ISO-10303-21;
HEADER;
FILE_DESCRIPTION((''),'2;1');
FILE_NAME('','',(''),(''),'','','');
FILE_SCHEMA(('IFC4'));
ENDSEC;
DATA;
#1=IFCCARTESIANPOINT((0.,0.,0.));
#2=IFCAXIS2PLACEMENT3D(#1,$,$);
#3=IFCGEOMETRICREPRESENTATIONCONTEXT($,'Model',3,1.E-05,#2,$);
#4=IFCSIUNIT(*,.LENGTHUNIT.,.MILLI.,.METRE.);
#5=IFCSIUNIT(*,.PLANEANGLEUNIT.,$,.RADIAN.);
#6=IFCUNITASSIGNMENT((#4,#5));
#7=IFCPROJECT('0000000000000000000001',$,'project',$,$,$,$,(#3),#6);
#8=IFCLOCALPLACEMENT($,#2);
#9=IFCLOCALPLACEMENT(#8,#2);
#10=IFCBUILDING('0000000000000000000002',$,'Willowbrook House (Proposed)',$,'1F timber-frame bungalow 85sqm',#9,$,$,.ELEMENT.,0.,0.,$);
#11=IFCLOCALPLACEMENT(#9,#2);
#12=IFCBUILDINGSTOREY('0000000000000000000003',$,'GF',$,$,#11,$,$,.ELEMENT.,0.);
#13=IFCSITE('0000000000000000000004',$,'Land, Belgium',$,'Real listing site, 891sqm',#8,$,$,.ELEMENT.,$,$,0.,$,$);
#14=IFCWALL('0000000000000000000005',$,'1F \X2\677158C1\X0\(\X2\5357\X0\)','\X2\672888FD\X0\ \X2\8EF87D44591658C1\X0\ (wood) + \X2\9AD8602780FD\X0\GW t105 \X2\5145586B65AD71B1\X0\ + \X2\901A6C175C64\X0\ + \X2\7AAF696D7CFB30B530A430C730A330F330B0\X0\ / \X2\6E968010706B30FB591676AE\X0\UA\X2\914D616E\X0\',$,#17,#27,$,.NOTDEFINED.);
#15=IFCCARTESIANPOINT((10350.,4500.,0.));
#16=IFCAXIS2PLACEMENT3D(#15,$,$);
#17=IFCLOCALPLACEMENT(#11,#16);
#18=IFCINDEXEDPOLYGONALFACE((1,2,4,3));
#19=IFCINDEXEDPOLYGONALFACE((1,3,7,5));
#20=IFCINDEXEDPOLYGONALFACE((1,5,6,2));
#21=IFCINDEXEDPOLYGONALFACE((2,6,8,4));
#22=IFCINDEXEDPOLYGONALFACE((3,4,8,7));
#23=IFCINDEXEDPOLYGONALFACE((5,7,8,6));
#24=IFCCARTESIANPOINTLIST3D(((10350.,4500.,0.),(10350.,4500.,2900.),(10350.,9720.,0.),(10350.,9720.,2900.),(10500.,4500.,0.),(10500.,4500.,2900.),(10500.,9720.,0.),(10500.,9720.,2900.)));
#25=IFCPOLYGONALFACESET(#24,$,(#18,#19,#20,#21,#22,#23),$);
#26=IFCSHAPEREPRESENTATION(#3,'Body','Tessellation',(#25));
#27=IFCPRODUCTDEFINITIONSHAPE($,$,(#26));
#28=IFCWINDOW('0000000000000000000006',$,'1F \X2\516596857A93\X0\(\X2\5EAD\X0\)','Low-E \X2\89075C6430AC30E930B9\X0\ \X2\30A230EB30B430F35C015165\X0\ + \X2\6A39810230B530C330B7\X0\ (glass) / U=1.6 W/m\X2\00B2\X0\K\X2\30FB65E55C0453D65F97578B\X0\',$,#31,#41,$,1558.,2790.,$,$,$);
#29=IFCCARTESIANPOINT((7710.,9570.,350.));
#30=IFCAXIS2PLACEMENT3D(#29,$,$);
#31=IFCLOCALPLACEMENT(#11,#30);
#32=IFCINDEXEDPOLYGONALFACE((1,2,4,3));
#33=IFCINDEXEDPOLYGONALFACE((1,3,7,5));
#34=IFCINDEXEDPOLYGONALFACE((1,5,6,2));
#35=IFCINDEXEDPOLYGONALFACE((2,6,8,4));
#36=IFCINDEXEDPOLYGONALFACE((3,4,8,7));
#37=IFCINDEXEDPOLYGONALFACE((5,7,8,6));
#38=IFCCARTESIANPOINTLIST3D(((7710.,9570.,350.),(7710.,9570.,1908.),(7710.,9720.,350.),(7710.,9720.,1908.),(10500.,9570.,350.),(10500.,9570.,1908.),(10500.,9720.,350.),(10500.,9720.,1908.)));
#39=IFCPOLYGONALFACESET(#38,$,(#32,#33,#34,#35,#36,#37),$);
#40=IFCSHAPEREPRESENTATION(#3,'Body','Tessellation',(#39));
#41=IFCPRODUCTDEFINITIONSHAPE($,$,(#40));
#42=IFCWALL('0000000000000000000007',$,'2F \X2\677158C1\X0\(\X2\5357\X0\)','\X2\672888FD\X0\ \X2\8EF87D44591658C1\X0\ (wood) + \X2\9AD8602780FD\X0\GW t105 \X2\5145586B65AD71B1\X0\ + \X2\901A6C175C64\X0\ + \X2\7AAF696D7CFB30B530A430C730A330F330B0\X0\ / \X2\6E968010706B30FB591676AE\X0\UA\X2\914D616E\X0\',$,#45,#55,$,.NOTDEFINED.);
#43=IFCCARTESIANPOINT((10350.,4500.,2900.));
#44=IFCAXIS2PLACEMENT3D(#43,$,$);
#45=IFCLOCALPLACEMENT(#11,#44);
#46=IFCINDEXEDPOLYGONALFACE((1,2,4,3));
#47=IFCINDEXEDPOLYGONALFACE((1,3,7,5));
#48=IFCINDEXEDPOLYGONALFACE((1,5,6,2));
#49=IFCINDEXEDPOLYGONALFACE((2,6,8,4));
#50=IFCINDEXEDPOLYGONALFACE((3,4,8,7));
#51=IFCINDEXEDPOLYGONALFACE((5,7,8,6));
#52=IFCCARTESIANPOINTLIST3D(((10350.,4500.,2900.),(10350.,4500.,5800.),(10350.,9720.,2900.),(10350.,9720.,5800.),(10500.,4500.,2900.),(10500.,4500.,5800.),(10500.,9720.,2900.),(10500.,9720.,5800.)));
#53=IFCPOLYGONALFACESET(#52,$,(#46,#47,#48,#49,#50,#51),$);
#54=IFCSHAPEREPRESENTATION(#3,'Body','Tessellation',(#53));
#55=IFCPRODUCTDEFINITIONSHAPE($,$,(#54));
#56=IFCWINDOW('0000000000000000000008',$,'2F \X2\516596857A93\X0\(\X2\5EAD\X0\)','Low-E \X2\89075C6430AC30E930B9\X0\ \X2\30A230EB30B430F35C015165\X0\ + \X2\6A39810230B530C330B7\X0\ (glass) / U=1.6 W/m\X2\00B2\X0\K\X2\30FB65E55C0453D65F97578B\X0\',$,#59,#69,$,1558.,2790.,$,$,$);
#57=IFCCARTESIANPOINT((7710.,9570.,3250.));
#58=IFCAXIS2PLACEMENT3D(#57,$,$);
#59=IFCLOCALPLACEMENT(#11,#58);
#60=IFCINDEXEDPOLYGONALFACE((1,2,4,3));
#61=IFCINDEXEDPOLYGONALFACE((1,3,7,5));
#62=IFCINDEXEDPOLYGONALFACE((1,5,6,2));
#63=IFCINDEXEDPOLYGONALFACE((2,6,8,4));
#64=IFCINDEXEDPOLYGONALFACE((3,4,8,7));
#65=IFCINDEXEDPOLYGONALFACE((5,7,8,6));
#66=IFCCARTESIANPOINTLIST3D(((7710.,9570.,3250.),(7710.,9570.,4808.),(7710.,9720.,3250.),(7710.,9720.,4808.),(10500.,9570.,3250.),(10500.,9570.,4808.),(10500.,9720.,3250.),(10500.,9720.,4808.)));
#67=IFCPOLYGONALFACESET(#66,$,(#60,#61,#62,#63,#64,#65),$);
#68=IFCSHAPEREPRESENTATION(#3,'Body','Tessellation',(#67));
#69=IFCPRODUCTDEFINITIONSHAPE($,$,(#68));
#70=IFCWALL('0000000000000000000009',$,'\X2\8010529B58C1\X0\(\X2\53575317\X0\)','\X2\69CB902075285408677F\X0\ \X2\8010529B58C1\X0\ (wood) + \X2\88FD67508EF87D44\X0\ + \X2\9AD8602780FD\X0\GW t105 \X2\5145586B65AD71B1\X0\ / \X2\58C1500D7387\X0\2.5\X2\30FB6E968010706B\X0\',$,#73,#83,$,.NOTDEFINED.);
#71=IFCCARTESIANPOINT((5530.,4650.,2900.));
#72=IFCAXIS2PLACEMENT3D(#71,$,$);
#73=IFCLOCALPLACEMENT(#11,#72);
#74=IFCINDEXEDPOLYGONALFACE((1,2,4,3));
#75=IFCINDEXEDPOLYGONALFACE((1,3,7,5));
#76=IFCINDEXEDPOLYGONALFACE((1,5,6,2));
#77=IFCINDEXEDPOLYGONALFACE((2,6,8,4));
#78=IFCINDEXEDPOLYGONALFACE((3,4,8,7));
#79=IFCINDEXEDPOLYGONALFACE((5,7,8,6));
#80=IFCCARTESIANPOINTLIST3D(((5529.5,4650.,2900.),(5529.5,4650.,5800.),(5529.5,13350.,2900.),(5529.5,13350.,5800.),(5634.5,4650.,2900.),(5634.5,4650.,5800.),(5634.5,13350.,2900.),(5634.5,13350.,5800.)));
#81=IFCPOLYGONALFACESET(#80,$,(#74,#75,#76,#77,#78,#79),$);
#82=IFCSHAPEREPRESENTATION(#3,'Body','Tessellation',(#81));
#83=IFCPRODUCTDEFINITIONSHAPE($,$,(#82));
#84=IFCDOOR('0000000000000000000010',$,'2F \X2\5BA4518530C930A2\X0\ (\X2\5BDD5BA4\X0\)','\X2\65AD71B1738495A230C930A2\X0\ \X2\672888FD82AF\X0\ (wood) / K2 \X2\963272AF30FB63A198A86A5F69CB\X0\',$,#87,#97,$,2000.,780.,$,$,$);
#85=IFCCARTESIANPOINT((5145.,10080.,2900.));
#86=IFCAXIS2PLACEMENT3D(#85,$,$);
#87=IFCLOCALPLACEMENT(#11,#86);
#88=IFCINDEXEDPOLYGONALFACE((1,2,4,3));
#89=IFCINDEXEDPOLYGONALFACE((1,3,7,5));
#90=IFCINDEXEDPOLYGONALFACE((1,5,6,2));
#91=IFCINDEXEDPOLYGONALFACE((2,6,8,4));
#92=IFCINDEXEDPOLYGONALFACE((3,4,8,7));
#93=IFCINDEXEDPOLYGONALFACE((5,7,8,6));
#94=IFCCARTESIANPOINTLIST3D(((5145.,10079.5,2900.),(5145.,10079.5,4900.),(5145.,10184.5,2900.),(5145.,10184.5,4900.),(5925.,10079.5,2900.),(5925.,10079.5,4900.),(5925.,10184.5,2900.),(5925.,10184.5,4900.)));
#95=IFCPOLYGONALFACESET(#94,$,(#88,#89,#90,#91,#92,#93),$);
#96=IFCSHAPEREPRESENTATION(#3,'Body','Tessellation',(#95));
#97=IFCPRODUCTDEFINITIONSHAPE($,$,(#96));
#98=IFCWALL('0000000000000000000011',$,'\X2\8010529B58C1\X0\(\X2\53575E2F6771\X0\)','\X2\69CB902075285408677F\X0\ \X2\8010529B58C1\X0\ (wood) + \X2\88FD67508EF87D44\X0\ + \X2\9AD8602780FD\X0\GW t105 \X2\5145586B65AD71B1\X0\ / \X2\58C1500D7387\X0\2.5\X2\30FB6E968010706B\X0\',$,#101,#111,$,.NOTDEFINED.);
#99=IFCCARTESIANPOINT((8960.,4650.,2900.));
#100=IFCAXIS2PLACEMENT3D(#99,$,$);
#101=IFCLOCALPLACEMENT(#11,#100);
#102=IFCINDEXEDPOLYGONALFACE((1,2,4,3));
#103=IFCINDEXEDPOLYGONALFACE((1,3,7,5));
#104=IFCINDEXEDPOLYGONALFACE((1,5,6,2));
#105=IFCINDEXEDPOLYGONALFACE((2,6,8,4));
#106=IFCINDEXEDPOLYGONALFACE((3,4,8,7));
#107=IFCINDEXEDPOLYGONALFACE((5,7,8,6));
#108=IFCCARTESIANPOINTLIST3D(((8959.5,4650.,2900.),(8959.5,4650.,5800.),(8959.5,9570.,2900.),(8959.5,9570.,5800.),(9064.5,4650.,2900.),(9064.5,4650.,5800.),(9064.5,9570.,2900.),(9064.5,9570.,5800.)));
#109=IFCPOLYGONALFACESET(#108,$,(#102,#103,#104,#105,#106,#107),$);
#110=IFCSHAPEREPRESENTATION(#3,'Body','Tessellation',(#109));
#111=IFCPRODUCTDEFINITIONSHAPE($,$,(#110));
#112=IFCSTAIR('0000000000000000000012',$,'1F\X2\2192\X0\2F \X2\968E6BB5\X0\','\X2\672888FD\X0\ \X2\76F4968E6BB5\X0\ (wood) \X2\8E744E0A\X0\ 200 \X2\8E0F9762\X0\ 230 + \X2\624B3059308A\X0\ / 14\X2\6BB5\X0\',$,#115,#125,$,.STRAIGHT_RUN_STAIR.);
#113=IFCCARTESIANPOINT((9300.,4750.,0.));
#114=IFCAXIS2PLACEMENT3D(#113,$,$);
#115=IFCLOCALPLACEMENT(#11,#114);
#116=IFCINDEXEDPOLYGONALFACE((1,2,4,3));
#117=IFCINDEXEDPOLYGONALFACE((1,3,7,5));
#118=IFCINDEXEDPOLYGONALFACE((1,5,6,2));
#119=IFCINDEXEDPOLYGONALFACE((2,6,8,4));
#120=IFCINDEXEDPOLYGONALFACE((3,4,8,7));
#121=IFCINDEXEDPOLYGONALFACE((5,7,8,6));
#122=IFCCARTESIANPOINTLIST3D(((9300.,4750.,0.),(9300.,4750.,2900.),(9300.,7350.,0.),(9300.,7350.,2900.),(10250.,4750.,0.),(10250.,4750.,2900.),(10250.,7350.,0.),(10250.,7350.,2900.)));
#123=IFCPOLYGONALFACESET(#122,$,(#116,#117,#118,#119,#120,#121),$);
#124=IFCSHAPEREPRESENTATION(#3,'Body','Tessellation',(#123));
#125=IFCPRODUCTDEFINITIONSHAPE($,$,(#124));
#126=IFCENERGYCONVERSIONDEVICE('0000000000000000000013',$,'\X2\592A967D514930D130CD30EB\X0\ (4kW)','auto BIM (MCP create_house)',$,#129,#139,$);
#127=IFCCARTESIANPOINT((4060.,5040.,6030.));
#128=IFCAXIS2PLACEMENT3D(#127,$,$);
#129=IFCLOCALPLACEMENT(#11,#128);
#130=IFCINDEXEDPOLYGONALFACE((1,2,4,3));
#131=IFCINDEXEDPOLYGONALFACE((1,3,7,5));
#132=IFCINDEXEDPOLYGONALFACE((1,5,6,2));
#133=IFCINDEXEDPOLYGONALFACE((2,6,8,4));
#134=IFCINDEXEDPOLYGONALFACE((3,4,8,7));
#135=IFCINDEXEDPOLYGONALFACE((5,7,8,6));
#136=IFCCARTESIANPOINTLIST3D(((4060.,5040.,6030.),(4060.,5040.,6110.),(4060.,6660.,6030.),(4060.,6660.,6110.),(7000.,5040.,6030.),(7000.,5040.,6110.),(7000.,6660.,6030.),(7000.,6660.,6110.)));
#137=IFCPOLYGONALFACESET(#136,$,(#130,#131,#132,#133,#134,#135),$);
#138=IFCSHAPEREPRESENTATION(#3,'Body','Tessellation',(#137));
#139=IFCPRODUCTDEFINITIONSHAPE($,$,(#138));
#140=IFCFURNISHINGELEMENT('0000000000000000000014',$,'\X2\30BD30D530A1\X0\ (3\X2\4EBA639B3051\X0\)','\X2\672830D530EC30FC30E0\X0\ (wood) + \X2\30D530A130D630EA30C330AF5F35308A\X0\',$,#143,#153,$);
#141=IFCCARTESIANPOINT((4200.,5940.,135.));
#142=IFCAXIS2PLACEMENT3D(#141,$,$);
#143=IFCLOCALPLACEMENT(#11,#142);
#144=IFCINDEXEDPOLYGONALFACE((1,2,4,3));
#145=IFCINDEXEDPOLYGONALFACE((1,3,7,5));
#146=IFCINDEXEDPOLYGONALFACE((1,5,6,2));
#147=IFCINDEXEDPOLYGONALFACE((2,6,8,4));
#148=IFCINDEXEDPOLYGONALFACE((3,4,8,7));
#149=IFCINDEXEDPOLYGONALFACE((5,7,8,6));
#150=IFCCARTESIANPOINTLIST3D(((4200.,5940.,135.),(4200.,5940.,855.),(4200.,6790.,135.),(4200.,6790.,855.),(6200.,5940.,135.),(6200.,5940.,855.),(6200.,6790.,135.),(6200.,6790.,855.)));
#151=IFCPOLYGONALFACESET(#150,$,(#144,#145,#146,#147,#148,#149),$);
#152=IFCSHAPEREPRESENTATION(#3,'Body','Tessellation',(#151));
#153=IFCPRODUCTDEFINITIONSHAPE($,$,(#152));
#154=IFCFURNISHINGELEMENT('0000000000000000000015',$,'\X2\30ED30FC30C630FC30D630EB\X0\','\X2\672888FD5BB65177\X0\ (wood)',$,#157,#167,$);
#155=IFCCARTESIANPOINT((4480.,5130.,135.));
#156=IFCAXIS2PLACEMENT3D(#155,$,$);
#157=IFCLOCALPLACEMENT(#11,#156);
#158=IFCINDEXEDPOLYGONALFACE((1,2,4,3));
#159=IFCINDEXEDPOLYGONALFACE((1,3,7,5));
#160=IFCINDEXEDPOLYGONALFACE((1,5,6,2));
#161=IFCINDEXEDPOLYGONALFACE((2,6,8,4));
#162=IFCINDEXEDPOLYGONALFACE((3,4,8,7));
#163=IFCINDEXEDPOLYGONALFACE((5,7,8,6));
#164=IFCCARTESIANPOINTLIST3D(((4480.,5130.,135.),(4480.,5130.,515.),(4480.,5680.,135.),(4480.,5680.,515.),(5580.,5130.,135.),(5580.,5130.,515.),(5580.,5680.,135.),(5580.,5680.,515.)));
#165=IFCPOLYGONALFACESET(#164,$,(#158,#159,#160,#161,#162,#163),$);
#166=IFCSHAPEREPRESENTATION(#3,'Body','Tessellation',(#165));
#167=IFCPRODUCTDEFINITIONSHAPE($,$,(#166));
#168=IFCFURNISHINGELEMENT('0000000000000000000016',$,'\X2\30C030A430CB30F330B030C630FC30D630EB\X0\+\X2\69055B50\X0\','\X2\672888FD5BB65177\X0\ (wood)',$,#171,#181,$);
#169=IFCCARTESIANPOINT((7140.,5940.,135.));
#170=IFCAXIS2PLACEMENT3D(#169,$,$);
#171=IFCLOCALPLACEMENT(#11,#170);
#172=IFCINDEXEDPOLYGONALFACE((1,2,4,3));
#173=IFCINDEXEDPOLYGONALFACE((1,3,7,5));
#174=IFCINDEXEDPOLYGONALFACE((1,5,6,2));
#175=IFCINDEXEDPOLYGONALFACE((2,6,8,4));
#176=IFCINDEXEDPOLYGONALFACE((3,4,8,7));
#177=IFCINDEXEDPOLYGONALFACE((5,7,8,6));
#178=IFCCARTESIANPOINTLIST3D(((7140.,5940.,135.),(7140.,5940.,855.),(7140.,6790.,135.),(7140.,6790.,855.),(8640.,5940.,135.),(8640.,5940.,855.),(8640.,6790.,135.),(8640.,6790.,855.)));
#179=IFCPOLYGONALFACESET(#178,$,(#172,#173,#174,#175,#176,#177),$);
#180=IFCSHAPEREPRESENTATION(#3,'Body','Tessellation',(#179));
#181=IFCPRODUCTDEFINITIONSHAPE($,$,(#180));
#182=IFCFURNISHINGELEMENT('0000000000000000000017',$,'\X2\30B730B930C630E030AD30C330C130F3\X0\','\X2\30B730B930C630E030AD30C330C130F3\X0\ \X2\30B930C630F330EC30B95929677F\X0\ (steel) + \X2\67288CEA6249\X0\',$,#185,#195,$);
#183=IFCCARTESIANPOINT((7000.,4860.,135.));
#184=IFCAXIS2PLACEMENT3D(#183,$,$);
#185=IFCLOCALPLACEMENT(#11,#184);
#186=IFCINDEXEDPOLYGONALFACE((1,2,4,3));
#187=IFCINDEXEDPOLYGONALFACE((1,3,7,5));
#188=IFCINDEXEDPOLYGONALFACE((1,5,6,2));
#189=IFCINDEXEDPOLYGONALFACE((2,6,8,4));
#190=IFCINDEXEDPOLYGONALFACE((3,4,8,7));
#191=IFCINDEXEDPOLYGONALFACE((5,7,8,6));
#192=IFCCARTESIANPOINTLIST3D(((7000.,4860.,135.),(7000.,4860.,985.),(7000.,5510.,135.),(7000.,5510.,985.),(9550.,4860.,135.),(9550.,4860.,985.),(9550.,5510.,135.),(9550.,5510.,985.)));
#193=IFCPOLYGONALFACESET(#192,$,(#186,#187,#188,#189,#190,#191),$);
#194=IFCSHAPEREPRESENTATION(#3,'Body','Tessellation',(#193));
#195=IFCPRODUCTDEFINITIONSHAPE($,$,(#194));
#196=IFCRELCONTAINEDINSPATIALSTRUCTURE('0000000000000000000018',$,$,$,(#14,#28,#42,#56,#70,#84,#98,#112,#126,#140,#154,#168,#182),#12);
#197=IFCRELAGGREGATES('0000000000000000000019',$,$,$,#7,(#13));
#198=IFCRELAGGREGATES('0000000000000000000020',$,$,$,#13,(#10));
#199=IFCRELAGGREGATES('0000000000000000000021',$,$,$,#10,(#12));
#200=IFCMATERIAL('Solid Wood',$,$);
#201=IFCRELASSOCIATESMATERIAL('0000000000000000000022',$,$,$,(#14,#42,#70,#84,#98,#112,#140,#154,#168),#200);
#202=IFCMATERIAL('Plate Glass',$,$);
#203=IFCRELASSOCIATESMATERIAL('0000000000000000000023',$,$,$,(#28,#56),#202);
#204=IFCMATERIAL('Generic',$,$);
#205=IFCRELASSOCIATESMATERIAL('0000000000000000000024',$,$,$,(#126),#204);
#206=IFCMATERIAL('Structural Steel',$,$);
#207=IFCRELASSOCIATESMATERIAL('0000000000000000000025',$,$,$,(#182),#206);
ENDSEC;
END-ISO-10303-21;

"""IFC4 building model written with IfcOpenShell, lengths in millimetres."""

from ifc_helpers import new_model, si_unit, frame, frame_2d, origin, place, context, project, spatial, rectangle, extrude, material, element, fill, save


model = new_model("IFC4")

# Units and contexts
model_context = context("Model", 3, precision=1e-05, world=origin())
ifc_project = project(units=[si_unit("LENGTHUNIT", "METRE", prefix="MILLI"), si_unit("PLANEANGLEUNIT", "RADIAN")], contexts=[model_context])

# Site, building, storey
site_placement = place(None, origin())
site = spatial("IfcSite", under=ifc_project, at=site_placement, Name="Land, Belgium", ObjectType="Real listing site, 891sqm", CompositionType="ELEMENT", RefElevation=0.0)
building_placement = place(site_placement, origin())
building = spatial("IfcBuilding", under=site, at=building_placement, Name="Willowbrook House (Proposed)", ObjectType="1F timber-frame bungalow 85sqm", CompositionType="ELEMENT", ElevationOfRefHeight=0.0, ElevationOfTerrain=0.0)
storey_placement = place(building_placement, origin())
storey = spatial("IfcBuildingStorey", under=building, at=storey_placement, Name="GF", CompositionType="ELEMENT", Elevation=0.0)

# Wall, opening, window
ifc_material_1 = material(Name="Solid Wood")
wall_1_placement = place(storey_placement, frame((10350.0, 4500.0, 0.0)))
wall_1 = element("IfcWall", 1, at=wall_1_placement, inside=storey, material=ifc_material_1, Name="1F 東壁(南)", Description="木製 軸組外壁 (wood) + 高性能GW t105 充填断熱 + 通気層 + 窯業系サイディング / 準耐火・外皮UA配慮", PredefinedType="NOTDEFINED", context=model_context, shape_type="SweptSolid", body=[
    extrude(rectangle(XDim=150.0, YDim=5220.0, at=frame_2d((75.0, 2610.0))), frame((10350.0, 4500.0, 0.0)), (0.0, 0.0, 1.0), 2900.0),
])
opening_1_placement = place(storey_placement, frame((7710.0, 9570.0, 350.0)))
opening_1 = element("IfcOpeningElement", 2, at=opening_1_placement, cuts=wall_1, PredefinedType="NOTDEFINED", context=model_context, shape_type="SweptSolid", body=[
    extrude(rectangle(XDim=2790.0, YDim=150.0, at=frame_2d((1395.0, 75.0))), frame((7710.0, 9570.0, 350.0)), (0.0, 0.0, 1.0), 1558.0),
])
ifc_material_2 = material(Name="Plate Glass")
window_1_placement = place(storey_placement, frame((7710.0, 9570.0, 350.0)))
window_1 = element("IfcWindow", 3, at=window_1_placement, inside=storey, material=ifc_material_2, Name="1F 入隅窓(庭)", Description="Low-E 複層ガラス アルゴン封入 + 樹脂サッシ (glass) / U=1.6 W/m²K・日射取得型", OverallHeight=1558.0, OverallWidth=2790.0, context=model_context, shape_type="SweptSolid", body=[
    extrude(rectangle(XDim=2790.0, YDim=150.0, at=frame_2d((1395.0, 75.0))), frame((7710.0, 9570.0, 350.0)), (0.0, 0.0, 1.0), 1558.0),
])
fill(opening_1, window_1)

# Wall, opening, window
wall_2_placement = place(storey_placement, frame((10350.0, 4500.0, 2900.0)))
wall_2 = element("IfcWall", 4, at=wall_2_placement, inside=storey, material=ifc_material_1, Name="2F 東壁(南)", Description="木製 軸組外壁 (wood) + 高性能GW t105 充填断熱 + 通気層 + 窯業系サイディング / 準耐火・外皮UA配慮", PredefinedType="NOTDEFINED", context=model_context, shape_type="SweptSolid", body=[
    extrude(rectangle(XDim=150.0, YDim=5220.0, at=frame_2d((75.0, 2610.0))), frame((10350.0, 4500.0, 2900.0)), (0.0, 0.0, 1.0), 2900.0),
])
opening_2_placement = place(storey_placement, frame((7710.0, 9570.0, 3250.0)))
opening_2 = element("IfcOpeningElement", 5, at=opening_2_placement, cuts=wall_2, PredefinedType="NOTDEFINED", context=model_context, shape_type="SweptSolid", body=[
    extrude(rectangle(XDim=2790.0, YDim=150.0, at=frame_2d((1395.0, 75.0))), frame((7710.0, 9570.0, 3250.0)), (0.0, 0.0, 1.0), 1558.0),
])
window_2_placement = place(storey_placement, frame((7710.0, 9570.0, 3250.0)))
window_2 = element("IfcWindow", 6, at=window_2_placement, inside=storey, material=ifc_material_2, Name="2F 入隅窓(庭)", Description="Low-E 複層ガラス アルゴン封入 + 樹脂サッシ (glass) / U=1.6 W/m²K・日射取得型", OverallHeight=1558.0, OverallWidth=2790.0, context=model_context, shape_type="SweptSolid", body=[
    extrude(rectangle(XDim=2790.0, YDim=150.0, at=frame_2d((1395.0, 75.0))), frame((7710.0, 9570.0, 3250.0)), (0.0, 0.0, 1.0), 1558.0),
])
fill(opening_2, window_2)

# Wall, opening, door
wall_3_placement = place(storey_placement, frame((5530.0, 4650.0, 2900.0)))
wall_3 = element("IfcWall", 7, at=wall_3_placement, inside=storey, material=ifc_material_1, Name="耐力壁(南北)", Description="構造用合板 耐力壁 (wood) + 製材軸組 + 高性能GW t105 充填断熱 / 壁倍率2.5・準耐火", PredefinedType="NOTDEFINED", context=model_context, shape_type="SweptSolid", body=[
    extrude(rectangle(XDim=105.0, YDim=8700.0, at=frame_2d((52.0, 4350.0))), frame((5530.0, 4650.0, 2900.0)), (0.0, 0.0, 1.0), 2900.0),
])
opening_3_placement = place(storey_placement, frame((5145.0, 10080.0, 2900.0)))
opening_3 = element("IfcOpeningElement", 8, at=opening_3_placement, cuts=wall_3, PredefinedType="NOTDEFINED", context=model_context, shape_type="SweptSolid", body=[
    extrude(rectangle(XDim=780.0, YDim=105.0, at=frame_2d((390.0, 52.0))), frame((5145.0, 10080.0, 2900.0)), (0.0, 0.0, 1.0), 2000.0),
])
door_1_placement = place(storey_placement, frame((5145.0, 10080.0, 2900.0)))
door_1 = element("IfcDoor", 9, at=door_1_placement, inside=storey, material=ifc_material_1, Name="2F 室内ドア (寝室)", Description="断熱玄関ドア 木製芯 (wood) / K2 防犯・採風機構", OverallHeight=2000.0, OverallWidth=780.0, context=model_context, shape_type="SweptSolid", body=[
    extrude(rectangle(XDim=780.0, YDim=105.0, at=frame_2d((390.0, 52.0))), frame((5145.0, 10080.0, 2900.0)), (0.0, 0.0, 1.0), 2000.0),
])
fill(opening_3, door_1)

# Wall
wall_4_placement = place(storey_placement, frame((8960.0, 4650.0, 2900.0)))
element("IfcWall", 10, at=wall_4_placement, inside=storey, material=ifc_material_1, Name="耐力壁(南帯東)", Description="構造用合板 耐力壁 (wood) + 製材軸組 + 高性能GW t105 充填断熱 / 壁倍率2.5・準耐火", PredefinedType="NOTDEFINED", context=model_context, shape_type="SweptSolid", body=[
    extrude(rectangle(XDim=105.0, YDim=4920.0, at=frame_2d((52.0, 2460.0))), frame((8960.0, 4650.0, 2900.0)), (0.0, 0.0, 1.0), 2900.0),
])

# Stair
stair_placement = place(storey_placement, frame((9300.0, 4750.0, 0.0)))
element("IfcStair", 11, at=stair_placement, inside=storey, material=ifc_material_1, Name="1F→2F 階段", Description="木製 直階段 (wood) 蹴上 200 踏面 230 + 手すり / 14段", PredefinedType="STRAIGHT_RUN_STAIR", context=model_context, shape_type="SweptSolid", body=[
    extrude(rectangle(XDim=950.0, YDim=2600.0, at=frame_2d((475.0, 1300.0))), frame((9300.0, 4750.0, 0.0)), (0.0, 0.0, 1.0), 2900.0),
])

# Energy conversion device
ifc_material_3 = material(Name="Generic")
energy_conversion_device_placement = place(storey_placement, frame((4060.0, 5040.0, 6030.0)))
element("IfcEnergyConversionDevice", 12, at=energy_conversion_device_placement, inside=storey, material=ifc_material_3, Name="太陽光パネル (4kW)", Description="auto BIM (MCP create_house)", context=model_context, shape_type="SweptSolid", body=[
    extrude(rectangle(XDim=2940.0, YDim=1620.0, at=frame_2d((1470.0, 810.0))), frame((4060.0, 5040.0, 6030.0)), (0.0, 0.0, 1.0), 80.0),
])

# Furnishing elements
furnishing_1_placement = place(storey_placement, frame((4200.0, 5940.0, 135.0)))
element("IfcFurnishingElement", 13, at=furnishing_1_placement, inside=storey, material=ifc_material_1, Name="ソファ (3人掛け)", Description="木フレーム (wood) + ファブリック張り", context=model_context, shape_type="SweptSolid", body=[
    extrude(rectangle(XDim=2000.0, YDim=850.0, at=frame_2d((1000.0, 425.0))), frame((4200.0, 5940.0, 135.0)), (0.0, 0.0, 1.0), 720.0),
])
furnishing_2_placement = place(storey_placement, frame((4480.0, 5130.0, 135.0)))
element("IfcFurnishingElement", 14, at=furnishing_2_placement, inside=storey, material=ifc_material_1, Name="ローテーブル", Description="木製家具 (wood)", context=model_context, shape_type="SweptSolid", body=[
    extrude(rectangle(XDim=1100.0, YDim=550.0, at=frame_2d((550.0, 275.0))), frame((4480.0, 5130.0, 135.0)), (0.0, 0.0, 1.0), 380.0),
])
furnishing_3_placement = place(storey_placement, frame((7140.0, 5940.0, 135.0)))
element("IfcFurnishingElement", 15, at=furnishing_3_placement, inside=storey, material=ifc_material_1, Name="ダイニングテーブル+椅子", Description="木製家具 (wood)", context=model_context, shape_type="SweptSolid", body=[
    extrude(rectangle(XDim=1500.0, YDim=850.0, at=frame_2d((750.0, 425.0))), frame((7140.0, 5940.0, 135.0)), (0.0, 0.0, 1.0), 720.0),
])
ifc_material_4 = material(Name="Structural Steel")
furnishing_4_placement = place(storey_placement, frame((7000.0, 4860.0, 135.0)))
element("IfcFurnishingElement", 16, at=furnishing_4_placement, inside=storey, material=ifc_material_4, Name="システムキッチン", Description="システムキッチン ステンレス天板 (steel) + 木質扉", context=model_context, shape_type="SweptSolid", body=[
    extrude(rectangle(XDim=2550.0, YDim=650.0, at=frame_2d((1275.0, 325.0))), frame((7000.0, 4860.0, 135.0)), (0.0, 0.0, 1.0), 850.0),
])

save(model, "model.ifc")
